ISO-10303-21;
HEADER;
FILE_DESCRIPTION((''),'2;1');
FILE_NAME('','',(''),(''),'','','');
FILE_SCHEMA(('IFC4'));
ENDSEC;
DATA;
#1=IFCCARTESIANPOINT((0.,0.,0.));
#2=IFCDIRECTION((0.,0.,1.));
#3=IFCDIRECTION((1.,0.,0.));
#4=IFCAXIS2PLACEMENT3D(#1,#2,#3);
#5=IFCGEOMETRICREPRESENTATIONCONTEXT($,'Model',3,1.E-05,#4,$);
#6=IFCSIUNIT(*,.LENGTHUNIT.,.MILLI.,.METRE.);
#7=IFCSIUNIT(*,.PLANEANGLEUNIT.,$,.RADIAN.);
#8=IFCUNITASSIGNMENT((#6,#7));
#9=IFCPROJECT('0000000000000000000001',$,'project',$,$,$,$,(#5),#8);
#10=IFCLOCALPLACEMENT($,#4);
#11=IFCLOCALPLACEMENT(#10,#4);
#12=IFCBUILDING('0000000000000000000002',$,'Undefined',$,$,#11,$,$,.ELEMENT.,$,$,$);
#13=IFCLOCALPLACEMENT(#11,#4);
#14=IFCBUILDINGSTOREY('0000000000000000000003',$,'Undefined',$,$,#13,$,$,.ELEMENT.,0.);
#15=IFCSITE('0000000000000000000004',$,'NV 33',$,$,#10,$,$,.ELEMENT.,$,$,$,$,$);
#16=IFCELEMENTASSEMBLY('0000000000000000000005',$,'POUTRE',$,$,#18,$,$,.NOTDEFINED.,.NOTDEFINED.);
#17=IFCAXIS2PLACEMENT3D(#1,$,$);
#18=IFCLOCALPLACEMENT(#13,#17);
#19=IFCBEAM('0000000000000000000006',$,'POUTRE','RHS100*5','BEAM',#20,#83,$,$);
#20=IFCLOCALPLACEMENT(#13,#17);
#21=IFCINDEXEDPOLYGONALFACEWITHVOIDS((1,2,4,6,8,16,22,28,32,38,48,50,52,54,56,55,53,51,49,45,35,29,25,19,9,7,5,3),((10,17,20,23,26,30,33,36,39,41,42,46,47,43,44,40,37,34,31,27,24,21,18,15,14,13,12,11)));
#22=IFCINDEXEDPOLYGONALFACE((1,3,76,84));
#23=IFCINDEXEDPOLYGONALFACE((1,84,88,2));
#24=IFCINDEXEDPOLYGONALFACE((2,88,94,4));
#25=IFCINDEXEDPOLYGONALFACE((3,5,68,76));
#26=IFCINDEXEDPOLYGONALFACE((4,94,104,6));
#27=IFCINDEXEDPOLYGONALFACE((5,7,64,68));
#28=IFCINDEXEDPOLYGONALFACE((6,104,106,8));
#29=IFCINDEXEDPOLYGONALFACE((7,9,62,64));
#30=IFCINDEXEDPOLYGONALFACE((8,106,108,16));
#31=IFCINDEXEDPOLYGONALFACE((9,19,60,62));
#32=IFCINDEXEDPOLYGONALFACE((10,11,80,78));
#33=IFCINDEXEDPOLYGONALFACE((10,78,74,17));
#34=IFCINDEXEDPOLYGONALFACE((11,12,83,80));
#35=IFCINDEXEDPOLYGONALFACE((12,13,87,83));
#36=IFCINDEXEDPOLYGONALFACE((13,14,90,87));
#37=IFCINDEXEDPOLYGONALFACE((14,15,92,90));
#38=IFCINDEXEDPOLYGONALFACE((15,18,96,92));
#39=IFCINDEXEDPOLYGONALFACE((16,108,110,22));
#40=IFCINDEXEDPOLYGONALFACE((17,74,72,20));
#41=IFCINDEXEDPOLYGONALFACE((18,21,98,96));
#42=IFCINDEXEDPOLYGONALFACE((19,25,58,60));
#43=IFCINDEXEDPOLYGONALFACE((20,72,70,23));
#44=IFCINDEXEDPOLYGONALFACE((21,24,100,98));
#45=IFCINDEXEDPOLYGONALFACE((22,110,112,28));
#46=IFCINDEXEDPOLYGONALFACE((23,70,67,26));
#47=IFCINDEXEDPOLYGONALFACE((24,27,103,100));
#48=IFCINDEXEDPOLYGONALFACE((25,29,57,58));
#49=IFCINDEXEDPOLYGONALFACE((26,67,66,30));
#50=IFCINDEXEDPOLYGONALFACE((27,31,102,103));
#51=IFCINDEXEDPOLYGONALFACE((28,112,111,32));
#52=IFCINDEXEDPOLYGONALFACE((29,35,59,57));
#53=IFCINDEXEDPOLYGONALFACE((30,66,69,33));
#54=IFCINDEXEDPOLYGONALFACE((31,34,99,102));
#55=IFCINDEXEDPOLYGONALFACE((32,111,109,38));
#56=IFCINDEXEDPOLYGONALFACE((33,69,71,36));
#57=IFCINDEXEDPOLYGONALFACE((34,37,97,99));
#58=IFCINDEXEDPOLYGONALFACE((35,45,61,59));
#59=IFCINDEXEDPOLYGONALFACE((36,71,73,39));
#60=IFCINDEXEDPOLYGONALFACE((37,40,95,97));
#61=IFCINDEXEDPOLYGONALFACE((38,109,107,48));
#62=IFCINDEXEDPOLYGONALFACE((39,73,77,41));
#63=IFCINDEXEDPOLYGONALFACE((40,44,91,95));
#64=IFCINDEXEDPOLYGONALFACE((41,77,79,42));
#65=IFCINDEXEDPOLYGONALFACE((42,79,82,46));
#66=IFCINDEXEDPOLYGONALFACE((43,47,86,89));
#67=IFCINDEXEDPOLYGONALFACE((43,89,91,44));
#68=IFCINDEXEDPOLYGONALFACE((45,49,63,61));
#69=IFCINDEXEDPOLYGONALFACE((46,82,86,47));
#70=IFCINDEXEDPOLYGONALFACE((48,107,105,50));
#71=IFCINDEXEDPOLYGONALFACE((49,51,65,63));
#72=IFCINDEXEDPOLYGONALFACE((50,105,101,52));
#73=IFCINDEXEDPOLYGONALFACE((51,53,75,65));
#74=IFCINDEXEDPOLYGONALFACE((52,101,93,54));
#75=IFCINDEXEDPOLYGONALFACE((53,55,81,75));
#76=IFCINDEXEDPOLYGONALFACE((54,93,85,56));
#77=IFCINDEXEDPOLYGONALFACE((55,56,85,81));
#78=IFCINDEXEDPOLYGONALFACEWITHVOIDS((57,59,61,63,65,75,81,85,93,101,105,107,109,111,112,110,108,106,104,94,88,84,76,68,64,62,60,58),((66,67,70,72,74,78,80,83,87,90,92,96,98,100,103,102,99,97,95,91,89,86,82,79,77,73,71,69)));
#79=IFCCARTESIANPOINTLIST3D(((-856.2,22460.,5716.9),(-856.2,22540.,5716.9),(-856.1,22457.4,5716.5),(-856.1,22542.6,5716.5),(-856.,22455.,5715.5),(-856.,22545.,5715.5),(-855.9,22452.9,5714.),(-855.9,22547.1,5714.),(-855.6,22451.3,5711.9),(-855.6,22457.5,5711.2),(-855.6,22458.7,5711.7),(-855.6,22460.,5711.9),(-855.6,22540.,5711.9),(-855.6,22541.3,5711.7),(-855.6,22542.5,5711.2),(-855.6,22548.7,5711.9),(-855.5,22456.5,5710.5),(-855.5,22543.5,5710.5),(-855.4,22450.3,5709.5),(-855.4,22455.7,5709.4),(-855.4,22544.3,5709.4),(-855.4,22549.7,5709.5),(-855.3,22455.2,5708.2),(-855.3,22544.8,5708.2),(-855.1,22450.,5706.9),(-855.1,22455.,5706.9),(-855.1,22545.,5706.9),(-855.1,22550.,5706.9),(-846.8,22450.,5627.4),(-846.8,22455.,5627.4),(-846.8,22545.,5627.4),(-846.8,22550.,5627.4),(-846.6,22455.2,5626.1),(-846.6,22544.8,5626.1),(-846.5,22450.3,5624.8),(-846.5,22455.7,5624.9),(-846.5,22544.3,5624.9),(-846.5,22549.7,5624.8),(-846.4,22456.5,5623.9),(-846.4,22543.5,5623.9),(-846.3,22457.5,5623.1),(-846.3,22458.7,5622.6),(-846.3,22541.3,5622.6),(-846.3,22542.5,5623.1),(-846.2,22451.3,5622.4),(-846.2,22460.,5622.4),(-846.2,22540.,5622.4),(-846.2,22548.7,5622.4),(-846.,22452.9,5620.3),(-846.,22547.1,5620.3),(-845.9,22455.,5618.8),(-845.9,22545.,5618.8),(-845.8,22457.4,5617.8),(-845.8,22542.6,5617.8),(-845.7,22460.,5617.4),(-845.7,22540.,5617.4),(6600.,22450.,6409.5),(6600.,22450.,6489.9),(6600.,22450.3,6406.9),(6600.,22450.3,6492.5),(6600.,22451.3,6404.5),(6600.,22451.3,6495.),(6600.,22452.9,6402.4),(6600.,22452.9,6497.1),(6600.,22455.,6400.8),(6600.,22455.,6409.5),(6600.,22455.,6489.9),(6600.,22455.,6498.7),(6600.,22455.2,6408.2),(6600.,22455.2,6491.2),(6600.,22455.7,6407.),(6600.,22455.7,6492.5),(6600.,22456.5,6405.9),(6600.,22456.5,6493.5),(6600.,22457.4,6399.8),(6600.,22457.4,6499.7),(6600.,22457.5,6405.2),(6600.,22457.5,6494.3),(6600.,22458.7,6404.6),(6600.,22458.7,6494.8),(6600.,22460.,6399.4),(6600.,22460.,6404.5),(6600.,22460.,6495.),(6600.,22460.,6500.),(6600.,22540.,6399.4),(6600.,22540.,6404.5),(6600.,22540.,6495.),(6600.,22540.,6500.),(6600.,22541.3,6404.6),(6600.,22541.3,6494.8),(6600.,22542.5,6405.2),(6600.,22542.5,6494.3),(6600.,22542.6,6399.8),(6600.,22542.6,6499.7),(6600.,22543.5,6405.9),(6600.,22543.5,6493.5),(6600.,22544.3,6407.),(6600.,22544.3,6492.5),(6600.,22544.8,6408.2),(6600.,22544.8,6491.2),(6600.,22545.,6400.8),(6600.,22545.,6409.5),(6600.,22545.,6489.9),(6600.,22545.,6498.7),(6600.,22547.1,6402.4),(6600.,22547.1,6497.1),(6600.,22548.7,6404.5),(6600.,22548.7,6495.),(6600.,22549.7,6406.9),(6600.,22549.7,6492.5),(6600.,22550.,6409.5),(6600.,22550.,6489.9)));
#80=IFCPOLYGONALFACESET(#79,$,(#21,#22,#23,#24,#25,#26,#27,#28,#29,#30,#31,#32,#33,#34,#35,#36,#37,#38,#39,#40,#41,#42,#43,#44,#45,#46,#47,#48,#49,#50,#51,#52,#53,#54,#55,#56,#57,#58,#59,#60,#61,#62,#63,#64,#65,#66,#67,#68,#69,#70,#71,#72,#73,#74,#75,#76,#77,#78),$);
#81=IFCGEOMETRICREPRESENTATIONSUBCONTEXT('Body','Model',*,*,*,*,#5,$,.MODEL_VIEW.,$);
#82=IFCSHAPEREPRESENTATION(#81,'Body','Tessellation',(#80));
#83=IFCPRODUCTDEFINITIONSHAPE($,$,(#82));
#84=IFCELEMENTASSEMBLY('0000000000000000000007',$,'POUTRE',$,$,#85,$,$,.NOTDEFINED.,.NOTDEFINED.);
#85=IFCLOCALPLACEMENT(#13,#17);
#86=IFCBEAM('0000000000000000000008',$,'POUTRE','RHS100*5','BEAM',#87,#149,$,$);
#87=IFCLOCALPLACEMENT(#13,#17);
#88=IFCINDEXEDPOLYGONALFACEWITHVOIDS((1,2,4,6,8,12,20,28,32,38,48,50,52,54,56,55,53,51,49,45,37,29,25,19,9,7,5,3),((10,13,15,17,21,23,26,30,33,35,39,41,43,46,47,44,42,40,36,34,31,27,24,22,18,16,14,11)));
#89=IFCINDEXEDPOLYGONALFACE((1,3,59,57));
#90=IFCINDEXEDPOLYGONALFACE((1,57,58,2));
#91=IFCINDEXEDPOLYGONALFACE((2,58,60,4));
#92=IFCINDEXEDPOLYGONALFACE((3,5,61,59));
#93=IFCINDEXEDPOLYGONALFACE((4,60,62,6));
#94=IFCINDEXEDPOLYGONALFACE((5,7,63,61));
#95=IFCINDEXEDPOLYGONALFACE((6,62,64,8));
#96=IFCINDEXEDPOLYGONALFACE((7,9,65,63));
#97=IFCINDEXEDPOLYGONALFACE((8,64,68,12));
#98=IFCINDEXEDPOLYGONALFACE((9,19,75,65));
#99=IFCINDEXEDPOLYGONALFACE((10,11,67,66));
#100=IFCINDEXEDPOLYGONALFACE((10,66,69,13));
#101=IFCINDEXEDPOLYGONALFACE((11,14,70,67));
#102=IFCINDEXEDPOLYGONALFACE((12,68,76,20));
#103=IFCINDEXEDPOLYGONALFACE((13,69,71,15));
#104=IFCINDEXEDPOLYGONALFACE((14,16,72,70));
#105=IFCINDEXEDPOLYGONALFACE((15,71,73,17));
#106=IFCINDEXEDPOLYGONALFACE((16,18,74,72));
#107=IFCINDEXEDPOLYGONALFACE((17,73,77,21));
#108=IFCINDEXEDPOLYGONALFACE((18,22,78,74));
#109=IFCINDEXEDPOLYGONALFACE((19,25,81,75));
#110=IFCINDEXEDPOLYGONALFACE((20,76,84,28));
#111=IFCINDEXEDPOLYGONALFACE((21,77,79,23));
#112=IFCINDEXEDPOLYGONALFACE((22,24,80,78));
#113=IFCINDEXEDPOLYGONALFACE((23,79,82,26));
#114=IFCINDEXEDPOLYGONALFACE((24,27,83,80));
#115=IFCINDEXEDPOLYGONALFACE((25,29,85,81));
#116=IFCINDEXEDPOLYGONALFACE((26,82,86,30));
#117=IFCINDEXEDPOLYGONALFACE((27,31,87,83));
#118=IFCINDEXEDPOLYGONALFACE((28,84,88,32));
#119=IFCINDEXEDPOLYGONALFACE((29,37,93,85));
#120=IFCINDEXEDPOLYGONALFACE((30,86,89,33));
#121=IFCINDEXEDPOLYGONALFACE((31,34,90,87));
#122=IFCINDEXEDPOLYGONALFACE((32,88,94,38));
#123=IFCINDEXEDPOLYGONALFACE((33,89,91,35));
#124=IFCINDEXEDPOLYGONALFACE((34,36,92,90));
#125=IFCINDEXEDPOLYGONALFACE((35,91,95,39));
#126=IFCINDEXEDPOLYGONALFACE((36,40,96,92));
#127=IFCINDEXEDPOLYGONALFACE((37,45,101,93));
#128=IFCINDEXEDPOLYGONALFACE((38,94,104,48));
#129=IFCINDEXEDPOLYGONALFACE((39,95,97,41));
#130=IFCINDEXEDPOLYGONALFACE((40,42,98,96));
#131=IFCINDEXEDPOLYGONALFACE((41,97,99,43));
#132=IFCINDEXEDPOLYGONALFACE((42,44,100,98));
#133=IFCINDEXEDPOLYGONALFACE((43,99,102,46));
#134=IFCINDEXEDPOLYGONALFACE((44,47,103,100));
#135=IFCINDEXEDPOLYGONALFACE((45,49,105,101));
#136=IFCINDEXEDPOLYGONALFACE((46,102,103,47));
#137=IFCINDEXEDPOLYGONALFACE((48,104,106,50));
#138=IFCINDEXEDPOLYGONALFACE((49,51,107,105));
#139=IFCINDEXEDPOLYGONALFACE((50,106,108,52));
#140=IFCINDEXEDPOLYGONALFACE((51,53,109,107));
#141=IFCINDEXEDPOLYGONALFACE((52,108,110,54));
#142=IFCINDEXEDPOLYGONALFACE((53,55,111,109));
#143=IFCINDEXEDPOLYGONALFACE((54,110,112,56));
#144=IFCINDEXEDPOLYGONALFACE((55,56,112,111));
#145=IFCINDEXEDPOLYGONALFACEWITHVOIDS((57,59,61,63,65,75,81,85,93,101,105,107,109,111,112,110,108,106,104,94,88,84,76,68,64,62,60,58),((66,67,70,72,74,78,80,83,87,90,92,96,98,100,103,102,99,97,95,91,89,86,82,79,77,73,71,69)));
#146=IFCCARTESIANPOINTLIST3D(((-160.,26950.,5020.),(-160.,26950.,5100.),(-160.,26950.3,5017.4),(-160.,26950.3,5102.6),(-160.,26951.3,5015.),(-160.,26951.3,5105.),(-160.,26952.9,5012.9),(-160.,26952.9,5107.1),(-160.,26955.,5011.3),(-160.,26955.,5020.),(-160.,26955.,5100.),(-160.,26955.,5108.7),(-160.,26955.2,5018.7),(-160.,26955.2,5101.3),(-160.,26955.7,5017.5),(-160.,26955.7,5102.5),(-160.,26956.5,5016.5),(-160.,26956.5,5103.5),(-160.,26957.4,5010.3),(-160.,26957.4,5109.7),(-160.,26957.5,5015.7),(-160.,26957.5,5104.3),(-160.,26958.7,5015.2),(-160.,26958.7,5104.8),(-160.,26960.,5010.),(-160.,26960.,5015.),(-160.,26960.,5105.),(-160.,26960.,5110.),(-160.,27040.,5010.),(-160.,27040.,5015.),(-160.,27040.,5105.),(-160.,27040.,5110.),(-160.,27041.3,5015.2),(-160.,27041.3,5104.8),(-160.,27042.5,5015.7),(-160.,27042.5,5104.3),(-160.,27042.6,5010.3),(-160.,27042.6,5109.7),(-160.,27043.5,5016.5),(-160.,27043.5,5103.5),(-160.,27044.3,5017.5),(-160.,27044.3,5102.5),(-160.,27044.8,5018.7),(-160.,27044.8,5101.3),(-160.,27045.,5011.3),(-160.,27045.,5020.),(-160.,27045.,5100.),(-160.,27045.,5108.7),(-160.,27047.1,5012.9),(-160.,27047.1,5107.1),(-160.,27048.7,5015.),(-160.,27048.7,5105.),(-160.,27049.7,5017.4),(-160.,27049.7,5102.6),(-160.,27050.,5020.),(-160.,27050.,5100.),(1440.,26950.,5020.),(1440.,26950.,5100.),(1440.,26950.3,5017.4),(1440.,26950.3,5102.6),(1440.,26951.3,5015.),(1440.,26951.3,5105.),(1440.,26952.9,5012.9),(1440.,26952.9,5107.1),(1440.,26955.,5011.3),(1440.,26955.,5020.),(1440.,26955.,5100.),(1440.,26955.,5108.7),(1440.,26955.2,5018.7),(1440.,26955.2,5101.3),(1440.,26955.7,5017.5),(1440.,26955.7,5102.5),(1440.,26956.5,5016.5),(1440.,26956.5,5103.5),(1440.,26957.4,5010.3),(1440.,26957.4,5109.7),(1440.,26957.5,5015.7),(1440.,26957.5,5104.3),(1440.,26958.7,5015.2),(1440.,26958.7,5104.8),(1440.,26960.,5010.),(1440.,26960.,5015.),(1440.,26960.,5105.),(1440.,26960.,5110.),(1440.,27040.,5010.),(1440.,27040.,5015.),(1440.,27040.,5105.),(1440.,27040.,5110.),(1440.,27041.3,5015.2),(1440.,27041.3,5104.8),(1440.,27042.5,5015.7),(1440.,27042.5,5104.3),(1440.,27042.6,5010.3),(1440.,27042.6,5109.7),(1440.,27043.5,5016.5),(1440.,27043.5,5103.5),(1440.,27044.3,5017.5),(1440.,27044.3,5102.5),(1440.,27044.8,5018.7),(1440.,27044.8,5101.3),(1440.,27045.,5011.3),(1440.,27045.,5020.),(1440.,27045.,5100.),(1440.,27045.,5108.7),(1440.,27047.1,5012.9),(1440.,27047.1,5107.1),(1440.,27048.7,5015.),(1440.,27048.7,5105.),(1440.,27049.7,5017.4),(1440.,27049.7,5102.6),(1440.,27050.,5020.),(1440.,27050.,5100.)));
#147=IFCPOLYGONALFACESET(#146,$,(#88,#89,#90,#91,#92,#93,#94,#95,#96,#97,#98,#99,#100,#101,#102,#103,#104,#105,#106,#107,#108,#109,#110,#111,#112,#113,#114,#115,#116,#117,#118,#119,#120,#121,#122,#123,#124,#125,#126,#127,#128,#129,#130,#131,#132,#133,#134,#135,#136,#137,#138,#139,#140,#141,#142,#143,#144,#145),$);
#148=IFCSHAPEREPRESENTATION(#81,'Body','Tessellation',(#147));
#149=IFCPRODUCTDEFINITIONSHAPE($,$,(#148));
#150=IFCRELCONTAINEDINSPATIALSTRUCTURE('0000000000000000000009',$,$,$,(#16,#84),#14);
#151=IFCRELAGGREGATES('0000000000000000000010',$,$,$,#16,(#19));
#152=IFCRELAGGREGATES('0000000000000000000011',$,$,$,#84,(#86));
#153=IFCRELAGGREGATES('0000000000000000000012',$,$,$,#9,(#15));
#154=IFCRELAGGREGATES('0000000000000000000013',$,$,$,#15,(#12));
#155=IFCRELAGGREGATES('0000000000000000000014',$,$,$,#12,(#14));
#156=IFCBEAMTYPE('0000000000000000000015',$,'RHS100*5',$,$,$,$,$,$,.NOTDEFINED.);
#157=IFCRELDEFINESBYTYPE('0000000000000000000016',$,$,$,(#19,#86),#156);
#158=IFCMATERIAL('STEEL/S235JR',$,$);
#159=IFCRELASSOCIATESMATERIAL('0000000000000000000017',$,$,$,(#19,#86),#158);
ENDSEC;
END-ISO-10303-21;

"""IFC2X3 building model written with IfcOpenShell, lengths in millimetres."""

from ifc_helpers import new_model, si_unit, frame, origin_with_axes, origin_2d_with_axis, place, context, subcontext, project, spatial, hollow_rectangle, extrude, clip, halfspace, material, type_object, element, aggregate, save


model = new_model("IFC2X3")

# Units and contexts
model_context = context("Model", 3, precision=1e-05, world=origin_with_axes())
body_context = subcontext(model_context, "Body", "Model", "MODEL_VIEW")
ifc_project = project(units=[si_unit("LENGTHUNIT", "METRE", prefix="MILLI"), si_unit("PLANEANGLEUNIT", "RADIAN")], contexts=[model_context])

# Site, building, storey
site_placement = place(None, origin_with_axes())
site = spatial("IfcSite", under=ifc_project, at=site_placement, Name="NV 33", CompositionType="ELEMENT")
building_placement = place(site_placement, origin_with_axes())
building = spatial("IfcBuilding", under=site, at=building_placement, Name="Undefined", CompositionType="ELEMENT")
storey_placement = place(building_placement, origin_with_axes())
storey = spatial("IfcBuildingStorey", under=building, at=storey_placement, Name="Undefined", CompositionType="ELEMENT", Elevation=0.0)

# Element assemblies, beams
ifc_material_1 = material(Name="STEEL/S235JR")
assembly_1_placement = place(storey_placement, origin_with_axes())
assembly_1 = element("IfcElementAssembly", 1, at=assembly_1_placement, inside=storey, Name="POUTRE", AssemblyPlace="NOTDEFINED", PredefinedType="NOTDEFINED")
beam_type_1 = type_object("IfcBeamType", Name="RHS100*5", PredefinedType="NOTDEFINED")
beam_1_placement = place(assembly_1_placement, frame((-850.9, 22500.0, 5667.2), z_axis=(0.104455, 0.0, -0.99453), x_axis=(0.99453, 0.0, 0.104455)))
beam_1 = element("IfcBeam", 2, at=beam_1_placement, type_object=beam_type_1, material=ifc_material_1, Name="POUTRE", Description="RHS100*5", ObjectType="BEAM", context=body_context, shape_type="Clipping", body=[
    clip(extrude(hollow_rectangle(XDim=100.0, YDim=100.0, WallThickness=5.0, InnerFilletRadius=5.0, OuterFilletRadius=10.0, at=origin_2d_with_axis()), frame((7527.2, 0.0, 0.0), z_axis=(-1.0, 0.0, 0.0), x_axis=(0.0, -1.0, 0.0)), (0.0, 0.0, 1.0), 7527.2), halfspace(frame((7497.2, -50.0, -50.0), z_axis=(0.99453, 0.0, 0.104455), x_axis=(-0.104455, 0.0, 0.99453)), False)),
])
aggregate(assembly_1, [beam_1])
assembly_2_placement = place(storey_placement, origin_with_axes())
assembly_2 = element("IfcElementAssembly", 3, at=assembly_2_placement, inside=storey, Name="POUTRE", AssemblyPlace="NOTDEFINED", PredefinedType="NOTDEFINED")
beam_2_placement = place(assembly_2_placement, frame((-160.0, 27000.0, 5060.0), z_axis=(0.0, -1.0, 0.0), x_axis=(1.0, 0.0, 0.0)))
beam_2 = element("IfcBeam", 4, at=beam_2_placement, type_object=beam_type_1, material=ifc_material_1, Name="POUTRE", Description="RHS100*5", ObjectType="BEAM", context=body_context, shape_type="SweptSolid", body=[
    extrude(hollow_rectangle(XDim=100.0, YDim=100.0, WallThickness=5.0, InnerFilletRadius=5.0, OuterFilletRadius=10.0, at=origin_2d_with_axis()), frame((1600.0, 0.0, 0.0), z_axis=(-1.0, 0.0, 0.0), x_axis=(0.0, -1.0, 0.0)), (0.0, 0.0, 1.0), 1600.0),
])
aggregate(assembly_2, [beam_2])

save(model, "model.ifc")
